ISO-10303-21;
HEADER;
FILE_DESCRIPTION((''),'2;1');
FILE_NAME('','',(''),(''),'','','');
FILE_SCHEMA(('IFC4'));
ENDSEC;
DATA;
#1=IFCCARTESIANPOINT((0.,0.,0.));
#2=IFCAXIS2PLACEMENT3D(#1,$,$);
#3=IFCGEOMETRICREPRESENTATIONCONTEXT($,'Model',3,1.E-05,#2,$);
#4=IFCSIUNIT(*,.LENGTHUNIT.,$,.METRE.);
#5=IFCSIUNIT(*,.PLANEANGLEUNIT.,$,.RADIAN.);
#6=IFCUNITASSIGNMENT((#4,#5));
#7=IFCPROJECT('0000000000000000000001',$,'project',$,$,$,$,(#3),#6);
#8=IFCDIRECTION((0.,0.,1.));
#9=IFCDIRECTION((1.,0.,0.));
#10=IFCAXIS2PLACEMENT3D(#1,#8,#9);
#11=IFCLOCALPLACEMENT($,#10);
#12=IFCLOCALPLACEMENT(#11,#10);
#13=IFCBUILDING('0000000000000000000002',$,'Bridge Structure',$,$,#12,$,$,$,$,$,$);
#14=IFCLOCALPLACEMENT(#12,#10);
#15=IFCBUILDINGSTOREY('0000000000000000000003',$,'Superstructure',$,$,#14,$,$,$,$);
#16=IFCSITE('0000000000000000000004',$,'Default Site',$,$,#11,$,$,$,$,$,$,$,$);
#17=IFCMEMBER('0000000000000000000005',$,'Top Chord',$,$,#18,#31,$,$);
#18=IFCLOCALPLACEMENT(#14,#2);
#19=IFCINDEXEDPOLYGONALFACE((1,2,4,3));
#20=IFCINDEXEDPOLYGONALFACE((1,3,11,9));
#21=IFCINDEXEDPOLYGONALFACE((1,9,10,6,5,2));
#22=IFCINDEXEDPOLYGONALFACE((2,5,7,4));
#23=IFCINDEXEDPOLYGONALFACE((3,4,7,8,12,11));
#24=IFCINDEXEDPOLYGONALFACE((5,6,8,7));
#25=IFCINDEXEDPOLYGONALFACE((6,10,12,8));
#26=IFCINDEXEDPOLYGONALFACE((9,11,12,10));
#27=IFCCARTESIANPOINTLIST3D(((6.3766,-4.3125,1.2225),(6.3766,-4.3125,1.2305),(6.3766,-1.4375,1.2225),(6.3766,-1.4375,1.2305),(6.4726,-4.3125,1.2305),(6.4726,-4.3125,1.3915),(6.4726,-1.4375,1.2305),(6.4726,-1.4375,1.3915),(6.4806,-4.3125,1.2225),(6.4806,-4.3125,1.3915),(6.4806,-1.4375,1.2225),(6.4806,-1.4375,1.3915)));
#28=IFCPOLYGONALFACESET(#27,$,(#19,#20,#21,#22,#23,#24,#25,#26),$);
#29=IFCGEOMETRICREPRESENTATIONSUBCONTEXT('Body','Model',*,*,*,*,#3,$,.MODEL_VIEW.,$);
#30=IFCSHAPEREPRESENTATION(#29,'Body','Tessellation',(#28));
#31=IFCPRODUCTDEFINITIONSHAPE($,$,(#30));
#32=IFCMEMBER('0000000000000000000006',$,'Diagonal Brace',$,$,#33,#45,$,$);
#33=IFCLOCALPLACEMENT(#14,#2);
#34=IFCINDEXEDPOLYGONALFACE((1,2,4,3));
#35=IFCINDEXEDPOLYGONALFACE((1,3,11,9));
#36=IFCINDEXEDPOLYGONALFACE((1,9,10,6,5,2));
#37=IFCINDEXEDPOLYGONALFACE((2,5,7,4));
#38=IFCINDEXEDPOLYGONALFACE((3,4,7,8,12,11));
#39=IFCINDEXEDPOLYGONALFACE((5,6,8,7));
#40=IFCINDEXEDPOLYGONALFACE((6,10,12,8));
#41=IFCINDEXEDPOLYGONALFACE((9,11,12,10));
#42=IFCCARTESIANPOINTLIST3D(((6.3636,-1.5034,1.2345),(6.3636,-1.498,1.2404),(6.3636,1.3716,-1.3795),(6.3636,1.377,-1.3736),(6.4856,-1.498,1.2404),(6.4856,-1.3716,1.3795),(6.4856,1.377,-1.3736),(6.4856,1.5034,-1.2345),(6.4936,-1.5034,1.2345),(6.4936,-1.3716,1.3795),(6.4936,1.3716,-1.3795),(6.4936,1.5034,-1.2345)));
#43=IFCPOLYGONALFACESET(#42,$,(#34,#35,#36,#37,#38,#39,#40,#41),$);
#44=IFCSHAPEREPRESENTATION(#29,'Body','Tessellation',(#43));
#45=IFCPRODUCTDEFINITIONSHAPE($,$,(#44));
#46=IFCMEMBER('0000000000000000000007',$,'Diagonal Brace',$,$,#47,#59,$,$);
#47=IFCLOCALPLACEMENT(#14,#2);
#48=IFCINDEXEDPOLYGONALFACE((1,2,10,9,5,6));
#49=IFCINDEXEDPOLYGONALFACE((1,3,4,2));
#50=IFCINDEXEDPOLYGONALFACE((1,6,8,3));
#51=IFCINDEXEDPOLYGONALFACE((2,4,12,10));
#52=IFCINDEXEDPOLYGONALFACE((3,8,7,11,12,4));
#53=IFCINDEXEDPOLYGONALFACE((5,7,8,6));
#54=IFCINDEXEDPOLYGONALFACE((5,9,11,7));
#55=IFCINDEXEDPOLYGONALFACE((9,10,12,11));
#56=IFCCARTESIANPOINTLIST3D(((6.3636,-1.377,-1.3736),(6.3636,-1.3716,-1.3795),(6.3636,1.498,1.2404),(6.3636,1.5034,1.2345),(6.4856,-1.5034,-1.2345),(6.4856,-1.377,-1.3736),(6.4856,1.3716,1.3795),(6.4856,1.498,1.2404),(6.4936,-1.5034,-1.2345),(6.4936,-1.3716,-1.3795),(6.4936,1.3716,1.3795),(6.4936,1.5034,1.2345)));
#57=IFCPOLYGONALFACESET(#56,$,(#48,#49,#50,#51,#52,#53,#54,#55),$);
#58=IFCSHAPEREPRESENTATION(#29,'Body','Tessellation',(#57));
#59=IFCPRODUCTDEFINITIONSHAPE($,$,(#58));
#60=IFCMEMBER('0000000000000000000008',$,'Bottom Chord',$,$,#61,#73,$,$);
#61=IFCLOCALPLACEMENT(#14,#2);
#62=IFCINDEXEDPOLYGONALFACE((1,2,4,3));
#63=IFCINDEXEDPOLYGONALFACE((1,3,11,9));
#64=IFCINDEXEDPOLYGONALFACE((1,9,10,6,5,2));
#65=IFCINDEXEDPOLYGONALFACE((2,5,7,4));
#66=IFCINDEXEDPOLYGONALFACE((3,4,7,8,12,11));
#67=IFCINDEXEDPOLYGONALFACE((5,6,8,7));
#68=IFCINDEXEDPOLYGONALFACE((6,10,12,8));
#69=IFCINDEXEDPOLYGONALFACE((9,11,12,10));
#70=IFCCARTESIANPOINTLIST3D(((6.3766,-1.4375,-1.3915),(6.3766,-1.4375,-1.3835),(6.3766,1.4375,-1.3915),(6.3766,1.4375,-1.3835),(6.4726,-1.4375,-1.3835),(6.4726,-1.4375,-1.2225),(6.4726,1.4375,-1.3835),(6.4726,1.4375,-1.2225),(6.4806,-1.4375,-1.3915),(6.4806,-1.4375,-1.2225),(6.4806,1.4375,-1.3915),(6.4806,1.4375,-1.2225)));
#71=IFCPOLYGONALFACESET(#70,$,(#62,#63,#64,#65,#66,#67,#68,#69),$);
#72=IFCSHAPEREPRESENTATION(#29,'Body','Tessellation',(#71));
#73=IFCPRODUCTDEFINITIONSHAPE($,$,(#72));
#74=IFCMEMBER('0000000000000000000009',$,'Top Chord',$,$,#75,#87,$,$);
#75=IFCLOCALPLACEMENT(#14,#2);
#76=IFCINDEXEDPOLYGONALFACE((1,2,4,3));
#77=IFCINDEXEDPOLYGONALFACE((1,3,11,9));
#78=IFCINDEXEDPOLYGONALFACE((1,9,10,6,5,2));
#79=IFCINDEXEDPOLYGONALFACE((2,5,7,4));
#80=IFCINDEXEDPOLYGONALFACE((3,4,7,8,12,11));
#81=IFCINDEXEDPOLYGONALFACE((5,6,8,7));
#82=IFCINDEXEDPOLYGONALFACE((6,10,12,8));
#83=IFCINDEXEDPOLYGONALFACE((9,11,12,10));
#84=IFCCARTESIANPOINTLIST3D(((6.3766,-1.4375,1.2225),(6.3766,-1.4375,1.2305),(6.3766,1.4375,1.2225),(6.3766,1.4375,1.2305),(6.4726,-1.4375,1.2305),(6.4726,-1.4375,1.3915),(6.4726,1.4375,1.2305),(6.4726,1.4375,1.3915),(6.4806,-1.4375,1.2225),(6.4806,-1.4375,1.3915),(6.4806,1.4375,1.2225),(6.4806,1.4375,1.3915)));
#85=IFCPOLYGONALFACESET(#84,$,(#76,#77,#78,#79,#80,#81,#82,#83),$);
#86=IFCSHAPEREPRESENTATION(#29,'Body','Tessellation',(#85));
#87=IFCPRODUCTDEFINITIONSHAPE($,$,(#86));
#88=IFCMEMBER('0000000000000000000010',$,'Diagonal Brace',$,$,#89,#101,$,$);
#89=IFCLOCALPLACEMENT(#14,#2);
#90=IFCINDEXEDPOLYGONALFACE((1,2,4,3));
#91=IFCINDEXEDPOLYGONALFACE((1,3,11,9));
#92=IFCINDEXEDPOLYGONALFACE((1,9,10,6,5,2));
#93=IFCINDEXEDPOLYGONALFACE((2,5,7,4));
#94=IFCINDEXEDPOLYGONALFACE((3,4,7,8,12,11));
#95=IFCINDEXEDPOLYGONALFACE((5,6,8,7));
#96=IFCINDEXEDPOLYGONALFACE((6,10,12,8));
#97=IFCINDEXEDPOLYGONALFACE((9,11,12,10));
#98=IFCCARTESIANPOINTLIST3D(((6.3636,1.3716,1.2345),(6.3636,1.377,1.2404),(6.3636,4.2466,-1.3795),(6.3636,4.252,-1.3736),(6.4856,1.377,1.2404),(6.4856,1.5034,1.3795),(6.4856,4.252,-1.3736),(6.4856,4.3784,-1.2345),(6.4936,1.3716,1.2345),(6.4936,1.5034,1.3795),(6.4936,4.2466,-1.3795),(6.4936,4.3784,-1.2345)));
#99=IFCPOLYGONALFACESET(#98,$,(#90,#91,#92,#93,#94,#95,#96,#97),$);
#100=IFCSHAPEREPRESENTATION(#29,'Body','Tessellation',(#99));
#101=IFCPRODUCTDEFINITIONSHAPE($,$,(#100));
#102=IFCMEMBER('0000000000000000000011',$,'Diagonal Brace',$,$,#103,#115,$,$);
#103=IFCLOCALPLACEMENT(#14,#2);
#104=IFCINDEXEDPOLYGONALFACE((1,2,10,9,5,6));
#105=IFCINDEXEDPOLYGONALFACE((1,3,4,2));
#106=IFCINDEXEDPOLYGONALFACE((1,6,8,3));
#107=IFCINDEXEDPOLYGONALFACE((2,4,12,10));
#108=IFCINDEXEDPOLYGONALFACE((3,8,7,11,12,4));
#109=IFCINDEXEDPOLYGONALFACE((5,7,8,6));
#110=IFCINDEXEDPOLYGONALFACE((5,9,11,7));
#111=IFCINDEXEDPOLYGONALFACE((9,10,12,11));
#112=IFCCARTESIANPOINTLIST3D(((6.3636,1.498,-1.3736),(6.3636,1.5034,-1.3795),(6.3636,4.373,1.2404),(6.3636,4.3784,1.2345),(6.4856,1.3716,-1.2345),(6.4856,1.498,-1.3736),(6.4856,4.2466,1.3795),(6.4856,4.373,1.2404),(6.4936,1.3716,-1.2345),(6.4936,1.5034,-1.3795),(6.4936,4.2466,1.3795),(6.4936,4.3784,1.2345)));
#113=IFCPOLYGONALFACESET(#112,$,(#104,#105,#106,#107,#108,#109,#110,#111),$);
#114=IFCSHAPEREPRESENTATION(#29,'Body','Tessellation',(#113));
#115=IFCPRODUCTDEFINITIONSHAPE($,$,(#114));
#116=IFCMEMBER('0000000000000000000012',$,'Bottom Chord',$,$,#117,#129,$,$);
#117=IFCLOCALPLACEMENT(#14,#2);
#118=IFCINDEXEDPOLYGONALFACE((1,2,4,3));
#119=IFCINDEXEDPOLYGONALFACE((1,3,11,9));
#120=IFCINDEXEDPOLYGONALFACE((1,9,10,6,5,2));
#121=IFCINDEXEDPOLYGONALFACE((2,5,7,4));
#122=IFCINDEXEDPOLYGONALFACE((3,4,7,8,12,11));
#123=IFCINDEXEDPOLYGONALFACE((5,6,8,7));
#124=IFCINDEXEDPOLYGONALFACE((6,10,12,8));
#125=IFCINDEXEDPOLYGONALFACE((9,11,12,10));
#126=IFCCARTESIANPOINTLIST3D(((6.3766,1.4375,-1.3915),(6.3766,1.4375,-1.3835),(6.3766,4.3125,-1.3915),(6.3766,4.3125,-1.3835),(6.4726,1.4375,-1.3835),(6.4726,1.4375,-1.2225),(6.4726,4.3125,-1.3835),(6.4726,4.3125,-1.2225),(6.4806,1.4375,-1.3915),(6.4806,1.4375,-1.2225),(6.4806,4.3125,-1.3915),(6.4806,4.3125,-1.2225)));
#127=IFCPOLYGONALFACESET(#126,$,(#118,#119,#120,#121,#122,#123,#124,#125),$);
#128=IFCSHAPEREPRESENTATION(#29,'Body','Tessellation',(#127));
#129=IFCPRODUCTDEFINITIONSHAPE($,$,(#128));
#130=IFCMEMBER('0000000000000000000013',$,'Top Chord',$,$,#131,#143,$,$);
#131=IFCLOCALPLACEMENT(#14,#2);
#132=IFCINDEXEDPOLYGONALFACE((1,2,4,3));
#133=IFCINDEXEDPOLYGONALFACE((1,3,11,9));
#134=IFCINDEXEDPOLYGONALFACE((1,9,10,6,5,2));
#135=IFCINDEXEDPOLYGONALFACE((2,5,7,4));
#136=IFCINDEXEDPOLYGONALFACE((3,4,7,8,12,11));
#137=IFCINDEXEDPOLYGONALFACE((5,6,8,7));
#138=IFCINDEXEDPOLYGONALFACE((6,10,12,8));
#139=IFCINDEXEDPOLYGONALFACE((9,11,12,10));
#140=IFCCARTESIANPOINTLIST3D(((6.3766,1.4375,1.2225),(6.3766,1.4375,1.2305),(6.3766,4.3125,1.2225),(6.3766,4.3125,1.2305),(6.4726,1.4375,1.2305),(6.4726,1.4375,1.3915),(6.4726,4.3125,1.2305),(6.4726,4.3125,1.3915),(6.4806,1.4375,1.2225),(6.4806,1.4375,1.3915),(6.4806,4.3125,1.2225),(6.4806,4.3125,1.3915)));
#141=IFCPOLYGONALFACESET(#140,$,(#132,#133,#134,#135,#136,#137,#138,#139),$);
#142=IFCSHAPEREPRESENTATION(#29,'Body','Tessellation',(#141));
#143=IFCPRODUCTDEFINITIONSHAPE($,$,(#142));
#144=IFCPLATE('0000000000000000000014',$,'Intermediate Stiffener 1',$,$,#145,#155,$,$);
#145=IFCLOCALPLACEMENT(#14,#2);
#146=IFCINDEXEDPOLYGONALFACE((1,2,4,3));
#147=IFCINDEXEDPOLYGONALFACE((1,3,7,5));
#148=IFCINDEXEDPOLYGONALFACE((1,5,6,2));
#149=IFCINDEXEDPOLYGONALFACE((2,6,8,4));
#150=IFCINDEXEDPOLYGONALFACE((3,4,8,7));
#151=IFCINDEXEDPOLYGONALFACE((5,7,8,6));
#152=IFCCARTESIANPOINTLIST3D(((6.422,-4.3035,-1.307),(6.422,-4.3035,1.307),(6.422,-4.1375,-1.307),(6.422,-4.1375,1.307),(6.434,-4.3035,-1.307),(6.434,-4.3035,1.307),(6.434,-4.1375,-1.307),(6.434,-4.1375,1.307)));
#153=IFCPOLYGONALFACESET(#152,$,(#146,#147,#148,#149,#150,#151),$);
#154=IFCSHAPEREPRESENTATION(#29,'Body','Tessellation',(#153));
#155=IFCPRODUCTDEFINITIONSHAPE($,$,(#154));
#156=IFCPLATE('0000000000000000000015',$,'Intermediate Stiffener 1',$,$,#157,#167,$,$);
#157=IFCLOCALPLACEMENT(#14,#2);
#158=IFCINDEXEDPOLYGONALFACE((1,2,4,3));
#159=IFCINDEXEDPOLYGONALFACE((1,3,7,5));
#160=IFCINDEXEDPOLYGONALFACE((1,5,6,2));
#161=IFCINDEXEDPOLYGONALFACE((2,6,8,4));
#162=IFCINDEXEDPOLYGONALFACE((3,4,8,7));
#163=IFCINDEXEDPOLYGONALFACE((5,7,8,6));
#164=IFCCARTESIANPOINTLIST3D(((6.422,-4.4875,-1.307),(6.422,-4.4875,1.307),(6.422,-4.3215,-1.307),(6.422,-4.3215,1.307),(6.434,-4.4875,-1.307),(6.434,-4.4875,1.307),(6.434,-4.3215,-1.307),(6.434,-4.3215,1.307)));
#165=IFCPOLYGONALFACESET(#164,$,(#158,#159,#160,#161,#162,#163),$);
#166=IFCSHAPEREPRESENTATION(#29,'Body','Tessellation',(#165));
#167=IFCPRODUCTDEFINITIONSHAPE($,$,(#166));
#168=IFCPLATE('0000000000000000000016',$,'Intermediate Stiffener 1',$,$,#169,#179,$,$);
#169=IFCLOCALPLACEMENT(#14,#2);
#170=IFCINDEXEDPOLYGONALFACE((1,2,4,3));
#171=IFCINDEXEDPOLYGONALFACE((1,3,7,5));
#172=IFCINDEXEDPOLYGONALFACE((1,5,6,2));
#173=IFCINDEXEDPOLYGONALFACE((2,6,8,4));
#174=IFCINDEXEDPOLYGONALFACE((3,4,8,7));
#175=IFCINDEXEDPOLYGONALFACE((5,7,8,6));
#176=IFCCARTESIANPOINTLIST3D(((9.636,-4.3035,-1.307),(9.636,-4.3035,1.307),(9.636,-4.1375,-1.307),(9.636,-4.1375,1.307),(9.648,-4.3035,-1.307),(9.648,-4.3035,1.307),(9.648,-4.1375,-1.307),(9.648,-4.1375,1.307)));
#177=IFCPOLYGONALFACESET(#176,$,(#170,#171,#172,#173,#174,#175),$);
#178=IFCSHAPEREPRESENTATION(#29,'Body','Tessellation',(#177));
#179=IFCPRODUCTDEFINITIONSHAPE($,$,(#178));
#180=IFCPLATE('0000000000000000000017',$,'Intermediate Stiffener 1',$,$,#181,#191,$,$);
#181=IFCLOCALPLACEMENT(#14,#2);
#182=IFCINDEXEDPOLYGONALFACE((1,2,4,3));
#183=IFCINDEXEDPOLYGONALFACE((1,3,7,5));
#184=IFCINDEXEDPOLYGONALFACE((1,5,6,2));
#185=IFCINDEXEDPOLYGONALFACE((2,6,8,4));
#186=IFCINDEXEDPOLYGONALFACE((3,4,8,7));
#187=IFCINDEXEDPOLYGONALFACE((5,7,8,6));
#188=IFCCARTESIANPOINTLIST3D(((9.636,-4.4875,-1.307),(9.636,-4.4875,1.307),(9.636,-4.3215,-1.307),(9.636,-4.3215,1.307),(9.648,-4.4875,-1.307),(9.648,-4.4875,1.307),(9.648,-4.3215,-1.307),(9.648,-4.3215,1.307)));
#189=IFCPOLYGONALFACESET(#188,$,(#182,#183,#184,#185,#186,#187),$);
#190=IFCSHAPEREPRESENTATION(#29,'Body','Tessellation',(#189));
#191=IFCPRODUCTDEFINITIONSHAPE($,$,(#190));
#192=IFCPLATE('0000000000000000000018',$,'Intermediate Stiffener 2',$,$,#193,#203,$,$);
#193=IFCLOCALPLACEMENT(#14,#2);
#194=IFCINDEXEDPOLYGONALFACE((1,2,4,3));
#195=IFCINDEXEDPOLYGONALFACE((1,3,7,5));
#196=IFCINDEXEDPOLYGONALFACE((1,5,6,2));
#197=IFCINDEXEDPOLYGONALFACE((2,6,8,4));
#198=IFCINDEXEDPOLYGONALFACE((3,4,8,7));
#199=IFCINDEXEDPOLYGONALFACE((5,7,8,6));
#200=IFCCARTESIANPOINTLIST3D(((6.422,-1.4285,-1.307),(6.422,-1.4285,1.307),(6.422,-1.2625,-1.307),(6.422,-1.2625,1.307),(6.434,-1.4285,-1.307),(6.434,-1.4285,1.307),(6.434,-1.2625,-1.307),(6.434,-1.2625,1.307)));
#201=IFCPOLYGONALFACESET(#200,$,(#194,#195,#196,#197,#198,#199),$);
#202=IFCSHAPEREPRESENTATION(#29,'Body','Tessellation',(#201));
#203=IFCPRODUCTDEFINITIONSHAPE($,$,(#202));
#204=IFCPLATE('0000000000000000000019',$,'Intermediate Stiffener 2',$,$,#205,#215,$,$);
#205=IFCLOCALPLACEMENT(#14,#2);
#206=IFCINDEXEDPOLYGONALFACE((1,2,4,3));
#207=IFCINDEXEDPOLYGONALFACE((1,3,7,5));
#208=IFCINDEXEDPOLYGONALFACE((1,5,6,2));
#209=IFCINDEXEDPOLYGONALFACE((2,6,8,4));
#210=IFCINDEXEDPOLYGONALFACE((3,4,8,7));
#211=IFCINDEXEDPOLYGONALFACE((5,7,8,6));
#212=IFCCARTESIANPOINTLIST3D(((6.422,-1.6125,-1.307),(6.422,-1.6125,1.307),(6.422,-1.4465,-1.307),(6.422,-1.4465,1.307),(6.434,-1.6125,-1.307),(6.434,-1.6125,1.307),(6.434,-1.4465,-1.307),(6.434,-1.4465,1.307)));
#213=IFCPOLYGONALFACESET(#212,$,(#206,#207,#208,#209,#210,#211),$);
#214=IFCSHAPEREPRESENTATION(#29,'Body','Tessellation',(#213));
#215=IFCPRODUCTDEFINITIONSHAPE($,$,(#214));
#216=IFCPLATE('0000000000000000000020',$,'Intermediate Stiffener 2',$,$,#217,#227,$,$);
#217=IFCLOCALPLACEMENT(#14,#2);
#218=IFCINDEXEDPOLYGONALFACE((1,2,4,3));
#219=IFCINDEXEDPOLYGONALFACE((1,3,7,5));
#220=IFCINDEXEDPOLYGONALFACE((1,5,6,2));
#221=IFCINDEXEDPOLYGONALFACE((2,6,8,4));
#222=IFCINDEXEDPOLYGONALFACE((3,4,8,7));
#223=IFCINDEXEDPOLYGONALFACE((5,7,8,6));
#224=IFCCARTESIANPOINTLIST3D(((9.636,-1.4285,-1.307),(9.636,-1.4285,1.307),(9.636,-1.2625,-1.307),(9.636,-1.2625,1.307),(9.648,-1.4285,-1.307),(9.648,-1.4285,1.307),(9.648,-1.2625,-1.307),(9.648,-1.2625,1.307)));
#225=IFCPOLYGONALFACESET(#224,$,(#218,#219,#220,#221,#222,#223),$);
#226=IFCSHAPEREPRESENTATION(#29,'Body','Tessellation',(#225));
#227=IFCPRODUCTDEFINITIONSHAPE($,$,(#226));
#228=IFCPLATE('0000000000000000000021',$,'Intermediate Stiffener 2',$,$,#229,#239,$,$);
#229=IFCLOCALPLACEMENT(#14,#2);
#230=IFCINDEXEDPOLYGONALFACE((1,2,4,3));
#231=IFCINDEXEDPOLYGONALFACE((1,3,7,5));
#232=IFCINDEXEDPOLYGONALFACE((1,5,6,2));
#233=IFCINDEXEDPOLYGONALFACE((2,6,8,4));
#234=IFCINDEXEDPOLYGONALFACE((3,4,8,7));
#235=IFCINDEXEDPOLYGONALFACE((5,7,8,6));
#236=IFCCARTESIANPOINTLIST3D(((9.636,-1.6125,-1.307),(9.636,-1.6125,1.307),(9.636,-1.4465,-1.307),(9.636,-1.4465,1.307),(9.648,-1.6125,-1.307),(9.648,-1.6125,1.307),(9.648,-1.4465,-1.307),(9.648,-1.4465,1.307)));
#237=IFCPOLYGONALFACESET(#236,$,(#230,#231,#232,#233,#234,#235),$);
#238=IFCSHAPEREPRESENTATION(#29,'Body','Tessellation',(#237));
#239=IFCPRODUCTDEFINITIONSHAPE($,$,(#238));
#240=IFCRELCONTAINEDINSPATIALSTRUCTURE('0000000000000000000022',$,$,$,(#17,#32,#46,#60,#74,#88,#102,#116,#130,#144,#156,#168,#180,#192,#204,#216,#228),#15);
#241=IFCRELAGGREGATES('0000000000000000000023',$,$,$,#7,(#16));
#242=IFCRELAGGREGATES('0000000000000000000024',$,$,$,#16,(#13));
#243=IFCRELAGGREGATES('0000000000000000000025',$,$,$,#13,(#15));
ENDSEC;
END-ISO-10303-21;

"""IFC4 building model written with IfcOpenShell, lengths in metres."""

from ifc_helpers import new_model, si_unit, frame, origin, origin_with_axes, origin_2d_with_axis, place, context, subcontext, project, spatial, rectangle, l_section, extrude, element, save


model = new_model("IFC4")

# Units and contexts
model_context = context("Model", 3, precision=1e-05, world=origin())
body_context = subcontext(model_context, "Body", "Model", "MODEL_VIEW")
ifc_project = project(units=[si_unit("LENGTHUNIT", "METRE"), si_unit("PLANEANGLEUNIT", "RADIAN")], contexts=[model_context])

# Site, building, storey
site_placement = place(None, origin_with_axes())
site = spatial("IfcSite", under=ifc_project, at=site_placement, Name="Default Site")
building_placement = place(site_placement, origin_with_axes())
building = spatial("IfcBuilding", under=site, at=building_placement, Name="Bridge Structure")
storey_placement = place(building_placement, origin_with_axes())
storey = spatial("IfcBuildingStorey", under=building, at=storey_placement, Name="Superstructure")

# Members
for number, where, z_axis, x_axis, name in (
    (1, (6.4286, -4.3125, 1.307), (0.0, 1.0, 0.0), (-1.0, 0.0, 0.0), "Top Chord"),
):
    element("IfcMember", number, at=place(storey_placement, frame(where, z_axis=z_axis, x_axis=x_axis)), inside=storey, Name=name, context=body_context, shape_type="SweptSolid", body=[
        extrude(l_section(Depth=0.169, Width=0.104, Thickness=0.008, at=origin_2d_with_axis()), origin_with_axes(), (0.0, 0.0, 1.0), 2.875),
    ])
for number, where, z_axis, x_axis, name in (
    (2, (6.4286, -1.4375, 1.307), (0.0, 0.739893, -0.672724), (-1.0, 0.0, 0.0), "Diagonal Brace"),
    (3, (6.4286, -1.4375, -1.307), (0.0, 0.739893, 0.672724), (-1.0, 0.0, 0.0), "Diagonal Brace"),
):
    element("IfcMember", number, at=place(storey_placement, frame(where, z_axis=z_axis, x_axis=x_axis)), inside=storey, Name=name, context=body_context, shape_type="SweptSolid", body=[
        extrude(l_section(Depth=0.196, Width=0.13, Thickness=0.008, at=origin_2d_with_axis()), origin_with_axes(), (0.0, 0.0, 1.0), 3.8857),
    ])
for number, where, z_axis, x_axis, name in (
    (4, (6.4286, -1.4375, -1.307), (0.0, 1.0, 0.0), (-1.0, 0.0, 0.0), "Bottom Chord"),
    (5, (6.4286, -1.4375, 1.307), (0.0, 1.0, 0.0), (-1.0, 0.0, 0.0), "Top Chord"),
):
    element("IfcMember", number, at=place(storey_placement, frame(where, z_axis=z_axis, x_axis=x_axis)), inside=storey, Name=name, context=body_context, shape_type="SweptSolid", body=[
        extrude(l_section(Depth=0.169, Width=0.104, Thickness=0.008, at=origin_2d_with_axis()), origin_with_axes(), (0.0, 0.0, 1.0), 2.875),
    ])
for number, where, z_axis, x_axis, name in (
    (6, (6.4286, 1.4375, 1.307), (0.0, 0.739893, -0.672724), (-1.0, 0.0, 0.0), "Diagonal Brace"),
    (7, (6.4286, 1.4375, -1.307), (0.0, 0.739893, 0.672724), (-1.0, 0.0, 0.0), "Diagonal Brace"),
):
    element("IfcMember", number, at=place(storey_placement, frame(where, z_axis=z_axis, x_axis=x_axis)), inside=storey, Name=name, context=body_context, shape_type="SweptSolid", body=[
        extrude(l_section(Depth=0.196, Width=0.13, Thickness=0.008, at=origin_2d_with_axis()), origin_with_axes(), (0.0, 0.0, 1.0), 3.8857),
    ])
for number, where, z_axis, x_axis, name in (
    (8, (6.4286, 1.4375, -1.307), (0.0, 1.0, 0.0), (-1.0, 0.0, 0.0), "Bottom Chord"),
    (9, (6.4286, 1.4375, 1.307), (0.0, 1.0, 0.0), (-1.0, 0.0, 0.0), "Top Chord"),
):
    element("IfcMember", number, at=place(storey_placement, frame(where, z_axis=z_axis, x_axis=x_axis)), inside=storey, Name=name, context=body_context, shape_type="SweptSolid", body=[
        extrude(l_section(Depth=0.169, Width=0.104, Thickness=0.008, at=origin_2d_with_axis()), origin_with_axes(), (0.0, 0.0, 1.0), 2.875),
    ])

# Plates
for number, where, z_axis, x_axis, name in (
    (10, (6.428, -4.2205, -1.307), (0.0, 0.0, 1.0), (1.0, 0.0, 0.0), "Intermediate Stiffener 1"),
    (11, (6.428, -4.4045, -1.307), (0.0, 0.0, 1.0), (1.0, 0.0, 0.0), "Intermediate Stiffener 1"),
    (12, (9.642, -4.2205, -1.307), (0.0, 0.0, 1.0), (1.0, 0.0, 0.0), "Intermediate Stiffener 1"),
    (13, (9.642, -4.4045, -1.307), (0.0, 0.0, 1.0), (1.0, 0.0, 0.0), "Intermediate Stiffener 1"),
    (14, (6.428, -1.3455, -1.307), (0.0, 0.0, 1.0), (1.0, 0.0, 0.0), "Intermediate Stiffener 2"),
    (15, (6.428, -1.5295, -1.307), (0.0, 0.0, 1.0), (1.0, 0.0, 0.0), "Intermediate Stiffener 2"),
    (16, (9.642, -1.3455, -1.307), (0.0, 0.0, 1.0), (1.0, 0.0, 0.0), "Intermediate Stiffener 2"),
    (17, (9.642, -1.5295, -1.307), (0.0, 0.0, 1.0), (1.0, 0.0, 0.0), "Intermediate Stiffener 2"),
):
    element("IfcPlate", number, at=place(storey_placement, frame(where, z_axis=z_axis, x_axis=x_axis)), inside=storey, Name=name, context=body_context, shape_type="SweptSolid", body=[
        extrude(rectangle(XDim=0.012, YDim=0.166, at=origin_2d_with_axis()), origin_with_axes(), (0.0, 0.0, 1.0), 2.614),
    ])

save(model, "model.ifc")
